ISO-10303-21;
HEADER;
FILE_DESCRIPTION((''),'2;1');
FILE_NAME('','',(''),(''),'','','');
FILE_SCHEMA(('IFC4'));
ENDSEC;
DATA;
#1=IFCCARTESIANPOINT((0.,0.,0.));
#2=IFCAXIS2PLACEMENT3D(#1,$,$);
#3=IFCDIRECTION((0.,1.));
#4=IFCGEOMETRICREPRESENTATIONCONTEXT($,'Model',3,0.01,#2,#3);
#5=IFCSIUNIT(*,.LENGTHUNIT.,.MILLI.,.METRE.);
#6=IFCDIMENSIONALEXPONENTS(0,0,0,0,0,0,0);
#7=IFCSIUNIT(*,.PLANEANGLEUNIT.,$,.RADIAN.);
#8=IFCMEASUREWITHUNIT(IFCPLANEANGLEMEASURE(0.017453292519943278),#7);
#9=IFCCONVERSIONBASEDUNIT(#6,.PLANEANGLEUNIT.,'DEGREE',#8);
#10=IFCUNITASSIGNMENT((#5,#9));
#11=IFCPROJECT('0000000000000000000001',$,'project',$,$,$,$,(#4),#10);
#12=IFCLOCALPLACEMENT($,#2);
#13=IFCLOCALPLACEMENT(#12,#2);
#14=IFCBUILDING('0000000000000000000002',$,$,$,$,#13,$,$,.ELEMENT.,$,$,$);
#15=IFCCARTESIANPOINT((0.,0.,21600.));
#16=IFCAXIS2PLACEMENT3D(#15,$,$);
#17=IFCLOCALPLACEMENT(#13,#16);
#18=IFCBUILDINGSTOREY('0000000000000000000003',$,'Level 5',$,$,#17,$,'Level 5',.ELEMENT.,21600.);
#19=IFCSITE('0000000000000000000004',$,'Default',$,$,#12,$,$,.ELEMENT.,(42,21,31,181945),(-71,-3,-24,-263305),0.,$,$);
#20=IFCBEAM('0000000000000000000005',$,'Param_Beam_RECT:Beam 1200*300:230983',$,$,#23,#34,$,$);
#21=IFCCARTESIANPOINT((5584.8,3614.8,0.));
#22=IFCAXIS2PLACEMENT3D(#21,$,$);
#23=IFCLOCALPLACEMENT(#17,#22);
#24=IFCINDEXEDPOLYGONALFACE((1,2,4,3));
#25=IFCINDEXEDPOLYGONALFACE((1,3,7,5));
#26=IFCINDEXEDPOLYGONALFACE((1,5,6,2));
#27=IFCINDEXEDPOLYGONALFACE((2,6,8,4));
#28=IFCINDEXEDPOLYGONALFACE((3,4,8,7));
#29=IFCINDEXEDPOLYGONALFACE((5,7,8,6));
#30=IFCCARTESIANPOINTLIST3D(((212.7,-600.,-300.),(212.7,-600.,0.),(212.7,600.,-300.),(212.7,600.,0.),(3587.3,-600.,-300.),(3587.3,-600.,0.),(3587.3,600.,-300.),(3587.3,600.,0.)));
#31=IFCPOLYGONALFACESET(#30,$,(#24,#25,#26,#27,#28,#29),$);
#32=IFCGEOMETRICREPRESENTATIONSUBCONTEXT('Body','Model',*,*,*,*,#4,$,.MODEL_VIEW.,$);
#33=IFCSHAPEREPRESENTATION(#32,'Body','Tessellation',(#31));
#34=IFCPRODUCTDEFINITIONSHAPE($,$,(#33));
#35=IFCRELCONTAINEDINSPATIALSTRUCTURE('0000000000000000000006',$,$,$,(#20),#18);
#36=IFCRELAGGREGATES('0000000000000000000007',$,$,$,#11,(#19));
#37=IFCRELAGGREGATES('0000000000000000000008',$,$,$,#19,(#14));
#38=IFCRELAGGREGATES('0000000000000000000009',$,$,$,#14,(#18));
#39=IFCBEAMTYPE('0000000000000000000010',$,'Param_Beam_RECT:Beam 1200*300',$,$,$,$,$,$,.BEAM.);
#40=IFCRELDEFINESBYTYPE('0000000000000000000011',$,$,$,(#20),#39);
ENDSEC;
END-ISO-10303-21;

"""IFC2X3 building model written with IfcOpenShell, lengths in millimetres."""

from ifc_helpers import new_model, entity, si_unit, converted_unit, direction, frame, frame_2d, origin, place, context, subcontext, project, spatial, rectangle, extrude, type_object, element, save


model = new_model("IFC2X3")

# Units and contexts
model_context = context("Model", 3, precision=0.01, world=origin(), true_north=direction((0.0, 1.0)))
body_context = subcontext(model_context, "Body", "Model", "MODEL_VIEW")
ifc_project = project(units=[si_unit("LENGTHUNIT", "METRE", prefix="MILLI"), converted_unit("PLANEANGLEUNIT", "DEGREE", entity("IfcPlaneAngleMeasure", 0.017453292519943278), si_unit("PLANEANGLEUNIT", "RADIAN"), dimensions=[0, 0, 0, 0, 0, 0, 0])], contexts=[model_context])

# Site, building, storey
site_placement = place(None, origin())
site = spatial("IfcSite", under=ifc_project, at=site_placement, Name="Default", CompositionType="ELEMENT", RefLatitude=(42, 21, 31, 181945), RefLongitude=(-71, -3, -24, -263305), RefElevation=0.0)
building_placement = place(site_placement, origin())
building = spatial("IfcBuilding", under=site, at=building_placement, CompositionType="ELEMENT")
storey_placement = place(building_placement, frame((0.0, 0.0, 21600.0)))
storey = spatial("IfcBuildingStorey", under=building, at=storey_placement, Name="Level 5", LongName="Level 5", CompositionType="ELEMENT", Elevation=21600.0)

# Beam
beam_type_1 = type_object("IfcBeamType", Name="Param_Beam_RECT:Beam 1200*300", PredefinedType="BEAM")
beam_1_placement = place(storey_placement, frame((5584.8, 3614.8, 0.0)))
element("IfcBeam", 1, at=beam_1_placement, inside=storey, type_object=beam_type_1, Name="Param_Beam_RECT:Beam 1200*300:230983", context=body_context, shape_type="SweptSolid", body=[
    extrude(rectangle(XDim=300.0, YDim=1200.0, at=frame_2d((0.0, 0.0), x_axis=(1.0, 0.0))), frame((212.7, 0.0, -150.0), z_axis=(1.0, 0.0, 0.0), x_axis=(0.0, 0.0, -1.0)), (0.0, 0.0, 1.0), 3374.6),
])

save(model, "model.ifc")
